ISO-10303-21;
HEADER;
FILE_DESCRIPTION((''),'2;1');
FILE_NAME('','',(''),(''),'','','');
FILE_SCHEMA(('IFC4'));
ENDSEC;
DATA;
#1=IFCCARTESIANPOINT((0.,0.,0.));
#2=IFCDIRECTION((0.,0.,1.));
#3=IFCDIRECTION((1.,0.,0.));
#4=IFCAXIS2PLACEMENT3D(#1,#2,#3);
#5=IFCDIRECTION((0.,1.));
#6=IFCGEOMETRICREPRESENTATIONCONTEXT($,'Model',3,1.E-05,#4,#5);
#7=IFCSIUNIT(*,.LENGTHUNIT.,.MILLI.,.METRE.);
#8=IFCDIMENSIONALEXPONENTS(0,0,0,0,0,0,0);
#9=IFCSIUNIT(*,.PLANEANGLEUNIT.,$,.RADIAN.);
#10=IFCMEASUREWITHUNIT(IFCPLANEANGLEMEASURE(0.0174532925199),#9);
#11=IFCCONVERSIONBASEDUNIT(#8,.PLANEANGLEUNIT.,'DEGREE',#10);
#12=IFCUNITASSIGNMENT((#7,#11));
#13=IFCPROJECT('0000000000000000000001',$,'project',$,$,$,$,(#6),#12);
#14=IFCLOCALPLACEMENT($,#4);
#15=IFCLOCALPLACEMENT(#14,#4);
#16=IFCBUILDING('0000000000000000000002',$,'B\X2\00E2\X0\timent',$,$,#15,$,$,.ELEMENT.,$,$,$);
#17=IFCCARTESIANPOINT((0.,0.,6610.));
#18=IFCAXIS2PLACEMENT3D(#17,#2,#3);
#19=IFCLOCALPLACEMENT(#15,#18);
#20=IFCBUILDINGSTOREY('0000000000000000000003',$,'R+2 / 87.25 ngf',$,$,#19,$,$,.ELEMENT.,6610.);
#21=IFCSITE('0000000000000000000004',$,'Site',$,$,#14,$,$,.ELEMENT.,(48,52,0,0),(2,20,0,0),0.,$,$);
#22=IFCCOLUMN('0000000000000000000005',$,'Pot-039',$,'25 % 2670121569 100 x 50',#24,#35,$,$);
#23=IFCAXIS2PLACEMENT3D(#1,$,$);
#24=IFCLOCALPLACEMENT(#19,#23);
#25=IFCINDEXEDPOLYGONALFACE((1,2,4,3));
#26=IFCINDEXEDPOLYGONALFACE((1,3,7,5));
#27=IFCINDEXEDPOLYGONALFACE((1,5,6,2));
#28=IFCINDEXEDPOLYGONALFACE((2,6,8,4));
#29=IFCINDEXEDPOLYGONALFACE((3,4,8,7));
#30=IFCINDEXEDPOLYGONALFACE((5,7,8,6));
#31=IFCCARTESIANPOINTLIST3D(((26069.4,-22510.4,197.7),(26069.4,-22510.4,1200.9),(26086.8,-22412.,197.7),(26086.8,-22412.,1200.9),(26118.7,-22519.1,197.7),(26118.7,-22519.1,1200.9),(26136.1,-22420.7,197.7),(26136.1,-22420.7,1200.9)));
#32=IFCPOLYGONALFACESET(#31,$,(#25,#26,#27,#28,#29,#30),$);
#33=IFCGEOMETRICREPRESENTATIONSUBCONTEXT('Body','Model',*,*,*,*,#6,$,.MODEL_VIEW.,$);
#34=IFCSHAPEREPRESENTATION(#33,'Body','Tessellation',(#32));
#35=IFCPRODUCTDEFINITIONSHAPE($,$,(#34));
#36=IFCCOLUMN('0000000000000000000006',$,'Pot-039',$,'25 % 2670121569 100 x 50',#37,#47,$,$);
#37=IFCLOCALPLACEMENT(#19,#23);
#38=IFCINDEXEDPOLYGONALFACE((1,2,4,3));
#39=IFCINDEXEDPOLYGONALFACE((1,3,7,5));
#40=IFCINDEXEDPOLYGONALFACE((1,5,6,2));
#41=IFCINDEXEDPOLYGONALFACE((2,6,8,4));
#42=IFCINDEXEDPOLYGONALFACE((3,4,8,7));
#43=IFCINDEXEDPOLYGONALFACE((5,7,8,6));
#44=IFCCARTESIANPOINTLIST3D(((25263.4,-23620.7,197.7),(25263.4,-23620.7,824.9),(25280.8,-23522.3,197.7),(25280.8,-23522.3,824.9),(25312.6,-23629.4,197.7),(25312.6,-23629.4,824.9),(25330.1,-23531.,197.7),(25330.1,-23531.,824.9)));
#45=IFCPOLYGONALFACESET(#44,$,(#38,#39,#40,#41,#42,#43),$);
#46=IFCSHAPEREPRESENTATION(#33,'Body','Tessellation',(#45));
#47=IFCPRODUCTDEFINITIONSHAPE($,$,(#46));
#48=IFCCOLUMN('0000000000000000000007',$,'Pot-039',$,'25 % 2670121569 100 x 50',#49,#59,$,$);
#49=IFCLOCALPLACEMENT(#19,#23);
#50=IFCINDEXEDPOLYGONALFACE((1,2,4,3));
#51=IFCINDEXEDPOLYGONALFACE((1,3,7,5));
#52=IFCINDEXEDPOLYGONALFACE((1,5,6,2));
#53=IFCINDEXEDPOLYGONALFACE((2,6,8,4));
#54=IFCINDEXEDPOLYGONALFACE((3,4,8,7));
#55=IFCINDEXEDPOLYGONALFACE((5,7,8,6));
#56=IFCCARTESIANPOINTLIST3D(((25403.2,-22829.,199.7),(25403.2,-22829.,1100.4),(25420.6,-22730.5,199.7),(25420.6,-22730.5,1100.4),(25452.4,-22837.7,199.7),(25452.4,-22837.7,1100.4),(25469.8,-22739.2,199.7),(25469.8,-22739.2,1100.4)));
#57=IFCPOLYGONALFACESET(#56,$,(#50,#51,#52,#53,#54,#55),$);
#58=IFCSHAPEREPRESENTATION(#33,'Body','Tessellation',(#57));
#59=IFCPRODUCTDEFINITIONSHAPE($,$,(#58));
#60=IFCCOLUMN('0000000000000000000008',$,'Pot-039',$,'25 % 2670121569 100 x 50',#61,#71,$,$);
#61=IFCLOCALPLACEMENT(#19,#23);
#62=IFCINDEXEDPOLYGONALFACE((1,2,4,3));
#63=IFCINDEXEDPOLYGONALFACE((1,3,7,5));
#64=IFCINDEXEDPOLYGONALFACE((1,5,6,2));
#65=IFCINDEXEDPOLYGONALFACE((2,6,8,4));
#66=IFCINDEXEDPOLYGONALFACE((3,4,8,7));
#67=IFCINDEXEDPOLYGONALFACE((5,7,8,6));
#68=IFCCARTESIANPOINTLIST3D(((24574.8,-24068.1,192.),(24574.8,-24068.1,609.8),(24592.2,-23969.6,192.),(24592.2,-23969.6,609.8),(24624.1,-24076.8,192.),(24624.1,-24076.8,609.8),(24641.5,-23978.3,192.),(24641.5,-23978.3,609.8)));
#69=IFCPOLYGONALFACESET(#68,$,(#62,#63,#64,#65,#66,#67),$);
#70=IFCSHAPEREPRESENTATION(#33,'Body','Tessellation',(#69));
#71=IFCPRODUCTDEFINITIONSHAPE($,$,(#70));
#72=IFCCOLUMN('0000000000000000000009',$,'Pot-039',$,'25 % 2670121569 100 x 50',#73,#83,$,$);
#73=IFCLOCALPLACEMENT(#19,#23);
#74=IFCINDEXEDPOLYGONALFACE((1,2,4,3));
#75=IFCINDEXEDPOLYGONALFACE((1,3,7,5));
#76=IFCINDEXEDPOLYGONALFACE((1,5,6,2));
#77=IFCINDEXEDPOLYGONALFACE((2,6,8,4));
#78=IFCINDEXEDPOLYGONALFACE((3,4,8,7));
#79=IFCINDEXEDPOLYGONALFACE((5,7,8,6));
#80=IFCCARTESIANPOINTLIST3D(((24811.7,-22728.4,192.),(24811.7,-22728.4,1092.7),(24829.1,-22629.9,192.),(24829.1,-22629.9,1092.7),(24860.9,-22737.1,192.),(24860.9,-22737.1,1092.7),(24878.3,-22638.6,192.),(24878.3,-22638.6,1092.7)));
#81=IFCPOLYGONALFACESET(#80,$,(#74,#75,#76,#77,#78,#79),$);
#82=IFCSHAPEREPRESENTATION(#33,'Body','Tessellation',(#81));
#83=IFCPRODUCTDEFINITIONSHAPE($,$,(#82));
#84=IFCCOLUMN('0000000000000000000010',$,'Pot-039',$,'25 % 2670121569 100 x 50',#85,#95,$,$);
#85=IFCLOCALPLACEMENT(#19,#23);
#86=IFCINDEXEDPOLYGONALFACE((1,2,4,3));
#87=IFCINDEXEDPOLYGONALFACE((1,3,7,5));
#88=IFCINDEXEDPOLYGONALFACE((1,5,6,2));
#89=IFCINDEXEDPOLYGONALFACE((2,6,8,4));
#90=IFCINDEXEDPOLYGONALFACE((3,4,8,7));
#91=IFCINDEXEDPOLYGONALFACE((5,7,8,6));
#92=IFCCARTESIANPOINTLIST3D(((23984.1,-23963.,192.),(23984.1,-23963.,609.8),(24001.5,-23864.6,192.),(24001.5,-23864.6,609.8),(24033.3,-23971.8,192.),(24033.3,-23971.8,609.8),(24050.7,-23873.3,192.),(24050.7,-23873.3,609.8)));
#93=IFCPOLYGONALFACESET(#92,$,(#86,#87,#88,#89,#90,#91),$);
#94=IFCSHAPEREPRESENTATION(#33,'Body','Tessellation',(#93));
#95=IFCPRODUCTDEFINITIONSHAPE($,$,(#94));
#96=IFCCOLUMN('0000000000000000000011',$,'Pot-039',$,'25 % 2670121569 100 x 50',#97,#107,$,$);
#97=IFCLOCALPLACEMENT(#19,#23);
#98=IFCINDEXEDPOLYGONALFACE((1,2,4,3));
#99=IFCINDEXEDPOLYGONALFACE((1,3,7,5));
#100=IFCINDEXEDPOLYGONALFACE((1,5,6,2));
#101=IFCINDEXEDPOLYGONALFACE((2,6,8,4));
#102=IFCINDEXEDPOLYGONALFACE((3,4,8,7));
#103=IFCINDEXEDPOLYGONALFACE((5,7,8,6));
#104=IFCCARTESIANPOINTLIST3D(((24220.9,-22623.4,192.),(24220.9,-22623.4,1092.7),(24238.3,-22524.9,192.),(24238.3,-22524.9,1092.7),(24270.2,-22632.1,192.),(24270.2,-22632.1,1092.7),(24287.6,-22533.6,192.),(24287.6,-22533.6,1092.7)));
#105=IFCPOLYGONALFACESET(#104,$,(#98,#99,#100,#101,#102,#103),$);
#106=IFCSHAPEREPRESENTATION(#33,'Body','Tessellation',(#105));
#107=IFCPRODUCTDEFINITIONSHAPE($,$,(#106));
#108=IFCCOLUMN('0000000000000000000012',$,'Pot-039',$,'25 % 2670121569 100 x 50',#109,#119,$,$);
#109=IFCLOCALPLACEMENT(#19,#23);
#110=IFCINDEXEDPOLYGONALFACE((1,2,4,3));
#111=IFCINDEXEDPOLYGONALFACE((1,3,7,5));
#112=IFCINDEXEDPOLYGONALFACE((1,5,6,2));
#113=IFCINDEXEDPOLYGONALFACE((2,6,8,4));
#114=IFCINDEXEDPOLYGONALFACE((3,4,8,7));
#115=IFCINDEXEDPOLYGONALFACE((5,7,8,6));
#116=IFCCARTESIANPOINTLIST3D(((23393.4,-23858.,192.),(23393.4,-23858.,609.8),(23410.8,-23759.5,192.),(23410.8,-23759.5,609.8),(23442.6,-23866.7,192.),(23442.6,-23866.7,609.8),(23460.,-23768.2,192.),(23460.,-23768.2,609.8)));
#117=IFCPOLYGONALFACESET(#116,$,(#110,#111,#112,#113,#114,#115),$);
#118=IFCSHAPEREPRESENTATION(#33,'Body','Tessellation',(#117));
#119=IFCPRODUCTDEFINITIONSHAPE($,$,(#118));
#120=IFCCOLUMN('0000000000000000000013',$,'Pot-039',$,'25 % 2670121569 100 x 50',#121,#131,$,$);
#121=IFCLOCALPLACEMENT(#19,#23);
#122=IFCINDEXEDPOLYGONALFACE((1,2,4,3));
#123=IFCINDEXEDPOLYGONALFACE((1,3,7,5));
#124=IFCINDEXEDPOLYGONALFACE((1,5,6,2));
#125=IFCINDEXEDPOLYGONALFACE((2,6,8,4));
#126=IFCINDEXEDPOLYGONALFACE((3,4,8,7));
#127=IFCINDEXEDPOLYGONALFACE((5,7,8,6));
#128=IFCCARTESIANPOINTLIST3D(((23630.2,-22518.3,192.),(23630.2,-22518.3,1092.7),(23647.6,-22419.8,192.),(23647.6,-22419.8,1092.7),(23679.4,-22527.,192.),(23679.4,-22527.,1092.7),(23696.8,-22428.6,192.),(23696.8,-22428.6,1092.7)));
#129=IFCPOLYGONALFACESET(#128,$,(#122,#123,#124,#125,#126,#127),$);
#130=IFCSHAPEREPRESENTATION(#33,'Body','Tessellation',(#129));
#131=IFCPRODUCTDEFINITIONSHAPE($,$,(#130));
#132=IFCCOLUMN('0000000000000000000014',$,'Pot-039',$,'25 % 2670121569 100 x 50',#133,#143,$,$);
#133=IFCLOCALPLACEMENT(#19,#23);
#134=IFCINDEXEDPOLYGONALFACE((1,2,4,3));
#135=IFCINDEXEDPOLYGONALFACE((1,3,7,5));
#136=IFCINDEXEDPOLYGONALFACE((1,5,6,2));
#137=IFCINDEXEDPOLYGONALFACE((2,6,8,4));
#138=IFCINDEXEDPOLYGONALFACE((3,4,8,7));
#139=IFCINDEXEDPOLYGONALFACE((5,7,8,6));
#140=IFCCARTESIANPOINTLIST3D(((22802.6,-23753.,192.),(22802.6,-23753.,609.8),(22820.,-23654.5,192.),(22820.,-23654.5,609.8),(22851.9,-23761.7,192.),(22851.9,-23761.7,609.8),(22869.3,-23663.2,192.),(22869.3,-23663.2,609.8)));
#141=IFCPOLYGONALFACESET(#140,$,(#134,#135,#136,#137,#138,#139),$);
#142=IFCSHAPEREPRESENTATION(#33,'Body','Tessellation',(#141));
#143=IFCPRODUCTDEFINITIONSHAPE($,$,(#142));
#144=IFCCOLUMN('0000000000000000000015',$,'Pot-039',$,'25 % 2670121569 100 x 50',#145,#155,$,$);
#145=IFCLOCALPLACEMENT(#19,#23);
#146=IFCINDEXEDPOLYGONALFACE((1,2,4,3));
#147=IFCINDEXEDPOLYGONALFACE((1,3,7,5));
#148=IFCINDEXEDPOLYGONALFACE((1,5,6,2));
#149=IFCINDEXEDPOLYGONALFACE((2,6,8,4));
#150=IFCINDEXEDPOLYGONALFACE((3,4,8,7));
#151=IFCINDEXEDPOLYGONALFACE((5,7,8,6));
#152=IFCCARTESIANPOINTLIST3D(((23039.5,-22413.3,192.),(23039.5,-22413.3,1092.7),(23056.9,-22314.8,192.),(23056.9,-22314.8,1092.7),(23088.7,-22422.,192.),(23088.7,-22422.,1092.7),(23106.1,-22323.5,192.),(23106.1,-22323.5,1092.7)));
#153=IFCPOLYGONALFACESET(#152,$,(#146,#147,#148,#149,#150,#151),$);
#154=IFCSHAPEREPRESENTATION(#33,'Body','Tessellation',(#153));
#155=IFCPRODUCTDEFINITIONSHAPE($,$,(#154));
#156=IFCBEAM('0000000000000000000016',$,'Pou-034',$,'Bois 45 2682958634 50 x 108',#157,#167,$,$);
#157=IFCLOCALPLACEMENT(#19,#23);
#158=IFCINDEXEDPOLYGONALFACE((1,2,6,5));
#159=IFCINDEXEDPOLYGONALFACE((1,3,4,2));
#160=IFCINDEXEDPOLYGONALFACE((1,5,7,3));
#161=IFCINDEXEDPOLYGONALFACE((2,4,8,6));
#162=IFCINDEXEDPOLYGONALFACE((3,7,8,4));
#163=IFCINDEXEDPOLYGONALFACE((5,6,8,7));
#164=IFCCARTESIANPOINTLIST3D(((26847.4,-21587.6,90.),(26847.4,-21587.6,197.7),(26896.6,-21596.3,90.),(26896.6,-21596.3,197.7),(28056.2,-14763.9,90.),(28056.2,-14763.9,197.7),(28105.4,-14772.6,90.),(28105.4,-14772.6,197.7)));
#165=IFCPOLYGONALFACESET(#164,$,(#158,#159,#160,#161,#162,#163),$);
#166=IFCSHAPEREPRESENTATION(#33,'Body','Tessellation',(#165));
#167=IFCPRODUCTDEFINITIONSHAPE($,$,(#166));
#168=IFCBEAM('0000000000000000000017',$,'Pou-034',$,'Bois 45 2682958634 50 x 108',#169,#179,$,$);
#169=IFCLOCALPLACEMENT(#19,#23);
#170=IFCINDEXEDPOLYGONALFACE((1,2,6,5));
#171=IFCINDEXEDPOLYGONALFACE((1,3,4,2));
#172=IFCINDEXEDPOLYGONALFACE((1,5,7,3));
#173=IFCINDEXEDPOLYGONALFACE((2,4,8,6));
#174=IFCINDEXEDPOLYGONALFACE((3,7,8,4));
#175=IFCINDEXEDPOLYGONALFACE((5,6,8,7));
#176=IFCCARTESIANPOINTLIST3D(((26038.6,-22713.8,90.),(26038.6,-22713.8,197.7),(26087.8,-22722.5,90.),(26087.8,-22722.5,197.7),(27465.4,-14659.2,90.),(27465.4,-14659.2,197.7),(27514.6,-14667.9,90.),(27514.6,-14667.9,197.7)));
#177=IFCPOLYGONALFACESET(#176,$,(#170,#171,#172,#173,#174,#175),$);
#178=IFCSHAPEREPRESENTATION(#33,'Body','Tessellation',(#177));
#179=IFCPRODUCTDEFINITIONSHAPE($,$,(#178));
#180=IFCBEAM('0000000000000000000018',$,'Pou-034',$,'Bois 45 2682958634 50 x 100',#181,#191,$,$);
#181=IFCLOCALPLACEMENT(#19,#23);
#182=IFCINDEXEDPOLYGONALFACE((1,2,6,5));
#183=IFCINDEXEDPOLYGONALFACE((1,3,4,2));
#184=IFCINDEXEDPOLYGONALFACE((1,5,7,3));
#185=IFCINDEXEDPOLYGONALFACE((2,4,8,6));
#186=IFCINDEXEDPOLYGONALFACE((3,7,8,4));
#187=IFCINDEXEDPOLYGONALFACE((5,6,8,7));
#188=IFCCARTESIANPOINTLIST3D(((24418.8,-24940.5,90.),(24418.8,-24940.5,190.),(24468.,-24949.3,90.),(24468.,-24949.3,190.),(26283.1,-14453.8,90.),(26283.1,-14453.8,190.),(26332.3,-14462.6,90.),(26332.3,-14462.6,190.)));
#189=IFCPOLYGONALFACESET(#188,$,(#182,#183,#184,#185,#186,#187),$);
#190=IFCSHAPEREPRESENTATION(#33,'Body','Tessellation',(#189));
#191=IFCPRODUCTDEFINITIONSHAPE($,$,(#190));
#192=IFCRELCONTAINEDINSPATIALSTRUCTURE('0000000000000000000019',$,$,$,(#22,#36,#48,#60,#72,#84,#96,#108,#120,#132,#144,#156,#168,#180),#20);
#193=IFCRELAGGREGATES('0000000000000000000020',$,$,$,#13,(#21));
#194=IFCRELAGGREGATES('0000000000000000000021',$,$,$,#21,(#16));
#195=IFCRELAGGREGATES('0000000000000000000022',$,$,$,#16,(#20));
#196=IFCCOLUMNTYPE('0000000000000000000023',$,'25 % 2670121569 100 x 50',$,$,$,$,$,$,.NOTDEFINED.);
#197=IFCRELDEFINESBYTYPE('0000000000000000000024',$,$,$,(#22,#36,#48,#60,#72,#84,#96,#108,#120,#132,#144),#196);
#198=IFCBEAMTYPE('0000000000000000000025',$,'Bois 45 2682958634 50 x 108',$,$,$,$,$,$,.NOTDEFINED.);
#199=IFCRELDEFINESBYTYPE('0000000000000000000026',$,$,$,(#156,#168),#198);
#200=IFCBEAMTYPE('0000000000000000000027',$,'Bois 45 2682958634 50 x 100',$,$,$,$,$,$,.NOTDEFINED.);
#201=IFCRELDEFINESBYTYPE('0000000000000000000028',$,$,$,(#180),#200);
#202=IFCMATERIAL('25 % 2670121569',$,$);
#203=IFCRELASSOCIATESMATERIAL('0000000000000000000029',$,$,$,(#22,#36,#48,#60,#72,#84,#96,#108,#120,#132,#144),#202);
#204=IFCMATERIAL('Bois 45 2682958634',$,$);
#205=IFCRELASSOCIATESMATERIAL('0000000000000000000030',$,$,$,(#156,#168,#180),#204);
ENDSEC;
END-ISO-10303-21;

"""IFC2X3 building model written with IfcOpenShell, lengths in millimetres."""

from ifc_helpers import new_model, entity, si_unit, converted_unit, direction, frame, frame_2d, origin_with_axes, origin_2d_with_axis, place, context, subcontext, project, spatial, rectangle, extrude, material, type_object, element, save


model = new_model("IFC2X3")

# Units and contexts
model_context = context("Model", 3, precision=1e-05, world=origin_with_axes(), true_north=direction((0.0, 1.0)))
body_context = subcontext(model_context, "Body", "Model", "MODEL_VIEW")
ifc_project = project(units=[si_unit("LENGTHUNIT", "METRE", prefix="MILLI"), converted_unit("PLANEANGLEUNIT", "DEGREE", entity("IfcPlaneAngleMeasure", 0.0174532925199), si_unit("PLANEANGLEUNIT", "RADIAN"), dimensions=[0, 0, 0, 0, 0, 0, 0])], contexts=[model_context])

# Site, building, storey
site_placement = place(None, origin_with_axes())
site = spatial("IfcSite", under=ifc_project, at=site_placement, Name="Site", CompositionType="ELEMENT", RefLatitude=(48, 52, 0, 0), RefLongitude=(2, 20, 0, 0), RefElevation=0.0)
building_placement = place(site_placement, origin_with_axes())
building = spatial("IfcBuilding", under=site, at=building_placement, Name="Bâtiment", CompositionType="ELEMENT")
storey_placement = place(building_placement, frame((0.0, 0.0, 6610.0), z_axis=(0.0, 0.0, 1.0), x_axis=(1.0, 0.0, 0.0)))
storey = spatial("IfcBuildingStorey", under=building, at=storey_placement, Name="R+2 / 87.25 ngf", CompositionType="ELEMENT", Elevation=6610.0)

# Columns
ifc_material_1 = material(Name="25 % 2670121569")
column_type = type_object("IfcColumnType", Name="25 % 2670121569 100 x 50", PredefinedType="NOTDEFINED")
column_1_placement = place(storey_placement, frame((26102.8, -22465.5, 197.7), z_axis=(0.0, 0.0, 1.0), x_axis=(0.17408, 0.984731, 0.0)))
element("IfcColumn", 1, at=column_1_placement, inside=storey, type_object=column_type, material=ifc_material_1, Name="Pot-039", ObjectType="25 % 2670121569 100 x 50", context=body_context, shape_type="SweptSolid", body=[
    extrude(rectangle(XDim=100.0, YDim=50.0, at=origin_2d_with_axis()), origin_with_axes(), (0.0, 0.0, 1.0), 1003.2),
])
column_2_placement = place(storey_placement, frame((25296.7, -23575.9, 197.7), z_axis=(0.0, 0.0, 1.0), x_axis=(0.17408, 0.984731, 0.0)))
element("IfcColumn", 2, at=column_2_placement, inside=storey, type_object=column_type, material=ifc_material_1, Name="Pot-039", ObjectType="25 % 2670121569 100 x 50", context=body_context, shape_type="SweptSolid", body=[
    extrude(rectangle(XDim=100.0, YDim=50.0, at=origin_2d_with_axis()), origin_with_axes(), (0.0, 0.0, 1.0), 627.2),
])
column_3_placement = place(storey_placement, frame((25436.5, -22784.1, 199.7), z_axis=(0.0, 0.0, 1.0), x_axis=(0.17408, 0.984731, 0.0)))
element("IfcColumn", 3, at=column_3_placement, inside=storey, type_object=column_type, material=ifc_material_1, Name="Pot-039", ObjectType="25 % 2670121569 100 x 50", context=body_context, shape_type="SweptSolid", body=[
    extrude(rectangle(XDim=100.0, YDim=50.0, at=origin_2d_with_axis()), origin_with_axes(), (0.0, 0.0, 1.0), 900.7),
])
column_4_placement = place(storey_placement, frame((24608.1, -24023.2, 192.0), z_axis=(0.0, 0.0, 1.0), x_axis=(0.17408, 0.984731, 0.0)))
element("IfcColumn", 4, at=column_4_placement, inside=storey, type_object=column_type, material=ifc_material_1, Name="Pot-039", ObjectType="25 % 2670121569 100 x 50", context=body_context, shape_type="SweptSolid", body=[
    extrude(rectangle(XDim=100.0, YDim=50.0, at=origin_2d_with_axis()), origin_with_axes(), (0.0, 0.0, 1.0), 417.8),
])
column_5_placement = place(storey_placement, frame((24845.0, -22683.5, 192.0), z_axis=(0.0, 0.0, 1.0), x_axis=(0.17408, 0.984731, 0.0)))
element("IfcColumn", 5, at=column_5_placement, inside=storey, type_object=column_type, material=ifc_material_1, Name="Pot-039", ObjectType="25 % 2670121569 100 x 50", context=body_context, shape_type="SweptSolid", body=[
    extrude(rectangle(XDim=100.0, YDim=50.0, at=origin_2d_with_axis()), origin_with_axes(), (0.0, 0.0, 1.0), 900.7),
])
column_6_placement = place(storey_placement, frame((24017.4, -23918.2, 192.0), z_axis=(0.0, 0.0, 1.0), x_axis=(0.17408, 0.984731, 0.0)))
element("IfcColumn", 6, at=column_6_placement, inside=storey, type_object=column_type, material=ifc_material_1, Name="Pot-039", ObjectType="25 % 2670121569 100 x 50", context=body_context, shape_type="SweptSolid", body=[
    extrude(rectangle(XDim=100.0, YDim=50.0, at=origin_2d_with_axis()), origin_with_axes(), (0.0, 0.0, 1.0), 417.8),
])
column_7_placement = place(storey_placement, frame((24254.3, -22578.5, 192.0), z_axis=(0.0, 0.0, 1.0), x_axis=(0.17408, 0.984731, 0.0)))
element("IfcColumn", 7, at=column_7_placement, inside=storey, type_object=column_type, material=ifc_material_1, Name="Pot-039", ObjectType="25 % 2670121569 100 x 50", context=body_context, shape_type="SweptSolid", body=[
    extrude(rectangle(XDim=100.0, YDim=50.0, at=origin_2d_with_axis()), origin_with_axes(), (0.0, 0.0, 1.0), 900.7),
])
column_8_placement = place(storey_placement, frame((23426.7, -23813.1, 192.0), z_axis=(0.0, 0.0, 1.0), x_axis=(0.17408, 0.984731, 0.0)))
element("IfcColumn", 8, at=column_8_placement, inside=storey, type_object=column_type, material=ifc_material_1, Name="Pot-039", ObjectType="25 % 2670121569 100 x 50", context=body_context, shape_type="SweptSolid", body=[
    extrude(rectangle(XDim=100.0, YDim=50.0, at=origin_2d_with_axis()), origin_with_axes(), (0.0, 0.0, 1.0), 417.8),
])
column_9_placement = place(storey_placement, frame((23663.5, -22473.4, 192.0), z_axis=(0.0, 0.0, 1.0), x_axis=(0.17408, 0.984731, 0.0)))
element("IfcColumn", 9, at=column_9_placement, inside=storey, type_object=column_type, material=ifc_material_1, Name="Pot-039", ObjectType="25 % 2670121569 100 x 50", context=body_context, shape_type="SweptSolid", body=[
    extrude(rectangle(XDim=100.0, YDim=50.0, at=origin_2d_with_axis()), origin_with_axes(), (0.0, 0.0, 1.0), 900.7),
])
column_10_placement = place(storey_placement, frame((22835.9, -23708.1, 192.0), z_axis=(0.0, 0.0, 1.0), x_axis=(0.17408, 0.984731, 0.0)))
element("IfcColumn", 10, at=column_10_placement, inside=storey, type_object=column_type, material=ifc_material_1, Name="Pot-039", ObjectType="25 % 2670121569 100 x 50", context=body_context, shape_type="SweptSolid", body=[
    extrude(rectangle(XDim=100.0, YDim=50.0, at=origin_2d_with_axis()), origin_with_axes(), (0.0, 0.0, 1.0), 417.8),
])
column_11_placement = place(storey_placement, frame((23072.8, -22368.4, 192.0), z_axis=(0.0, 0.0, 1.0), x_axis=(0.17408, 0.984731, 0.0)))
element("IfcColumn", 11, at=column_11_placement, inside=storey, type_object=column_type, material=ifc_material_1, Name="Pot-039", ObjectType="25 % 2670121569 100 x 50", context=body_context, shape_type="SweptSolid", body=[
    extrude(rectangle(XDim=100.0, YDim=50.0, at=origin_2d_with_axis()), origin_with_axes(), (0.0, 0.0, 1.0), 900.7),
])

# Beams
ifc_material_2 = material(Name="Bois 45 2682958634")
beam_type_1 = type_object("IfcBeamType", Name="Bois 45 2682958634 50 x 108", PredefinedType="NOTDEFINED")
beam_1_placement = place(storey_placement, frame((26872.0, -21592.0, 197.7), z_axis=(0.0, 0.0, 1.0), x_axis=(0.98467, -0.17443, 0.0)))
element("IfcBeam", 12, at=beam_1_placement, inside=storey, type_object=beam_type_1, material=ifc_material_2, Name="Pou-034", ObjectType="Bois 45 2682958634 50 x 108", context=body_context, shape_type="SweptSolid", body=[
    extrude(rectangle(XDim=107.7, YDim=50.0, at=frame_2d((-53.9, 0.0), x_axis=(1.0, 0.0))), frame((0.0, 0.0, 0.0), z_axis=(0.0, 1.0, 0.0), x_axis=(0.0, 0.0, 1.0)), (0.0, 0.0, 1.0), 6930.0),
])
beam_2_placement = place(storey_placement, frame((26063.2, -22718.1, 197.7), z_axis=(0.0, 0.0, 1.0), x_axis=(0.98467, -0.17443, 0.0)))
element("IfcBeam", 13, at=beam_2_placement, inside=storey, type_object=beam_type_1, material=ifc_material_2, Name="Pou-034", ObjectType="Bois 45 2682958634 50 x 108", context=body_context, shape_type="SweptSolid", body=[
    extrude(rectangle(XDim=107.7, YDim=50.0, at=frame_2d((-53.9, 0.0), x_axis=(1.0, 0.0))), frame((0.0, 0.0, 0.0), z_axis=(0.0, 1.0, 0.0), x_axis=(0.0, 0.0, 1.0)), (0.0, 0.0, 1.0), 8180.0),
])
beam_type_2 = type_object("IfcBeamType", Name="Bois 45 2682958634 50 x 100", PredefinedType="NOTDEFINED")
beam_3_placement = place(storey_placement, frame((24443.4, -24944.9, 190.0), z_axis=(0.0, 0.0, 1.0), x_axis=(0.984562, -0.175035, 0.0)))
element("IfcBeam", 14, at=beam_3_placement, inside=storey, type_object=beam_type_2, material=ifc_material_2, Name="Pou-034", ObjectType="Bois 45 2682958634 50 x 100", context=body_context, shape_type="SweptSolid", body=[
    extrude(rectangle(XDim=100.0, YDim=50.0, at=frame_2d((-50.0, 0.0), x_axis=(1.0, 0.0))), frame((0.0, 0.0, 0.0), z_axis=(0.0, 1.0, 0.0), x_axis=(0.0, 0.0, 1.0)), (0.0, 0.0, 1.0), 10651.1),
])

save(model, "model.ifc")
